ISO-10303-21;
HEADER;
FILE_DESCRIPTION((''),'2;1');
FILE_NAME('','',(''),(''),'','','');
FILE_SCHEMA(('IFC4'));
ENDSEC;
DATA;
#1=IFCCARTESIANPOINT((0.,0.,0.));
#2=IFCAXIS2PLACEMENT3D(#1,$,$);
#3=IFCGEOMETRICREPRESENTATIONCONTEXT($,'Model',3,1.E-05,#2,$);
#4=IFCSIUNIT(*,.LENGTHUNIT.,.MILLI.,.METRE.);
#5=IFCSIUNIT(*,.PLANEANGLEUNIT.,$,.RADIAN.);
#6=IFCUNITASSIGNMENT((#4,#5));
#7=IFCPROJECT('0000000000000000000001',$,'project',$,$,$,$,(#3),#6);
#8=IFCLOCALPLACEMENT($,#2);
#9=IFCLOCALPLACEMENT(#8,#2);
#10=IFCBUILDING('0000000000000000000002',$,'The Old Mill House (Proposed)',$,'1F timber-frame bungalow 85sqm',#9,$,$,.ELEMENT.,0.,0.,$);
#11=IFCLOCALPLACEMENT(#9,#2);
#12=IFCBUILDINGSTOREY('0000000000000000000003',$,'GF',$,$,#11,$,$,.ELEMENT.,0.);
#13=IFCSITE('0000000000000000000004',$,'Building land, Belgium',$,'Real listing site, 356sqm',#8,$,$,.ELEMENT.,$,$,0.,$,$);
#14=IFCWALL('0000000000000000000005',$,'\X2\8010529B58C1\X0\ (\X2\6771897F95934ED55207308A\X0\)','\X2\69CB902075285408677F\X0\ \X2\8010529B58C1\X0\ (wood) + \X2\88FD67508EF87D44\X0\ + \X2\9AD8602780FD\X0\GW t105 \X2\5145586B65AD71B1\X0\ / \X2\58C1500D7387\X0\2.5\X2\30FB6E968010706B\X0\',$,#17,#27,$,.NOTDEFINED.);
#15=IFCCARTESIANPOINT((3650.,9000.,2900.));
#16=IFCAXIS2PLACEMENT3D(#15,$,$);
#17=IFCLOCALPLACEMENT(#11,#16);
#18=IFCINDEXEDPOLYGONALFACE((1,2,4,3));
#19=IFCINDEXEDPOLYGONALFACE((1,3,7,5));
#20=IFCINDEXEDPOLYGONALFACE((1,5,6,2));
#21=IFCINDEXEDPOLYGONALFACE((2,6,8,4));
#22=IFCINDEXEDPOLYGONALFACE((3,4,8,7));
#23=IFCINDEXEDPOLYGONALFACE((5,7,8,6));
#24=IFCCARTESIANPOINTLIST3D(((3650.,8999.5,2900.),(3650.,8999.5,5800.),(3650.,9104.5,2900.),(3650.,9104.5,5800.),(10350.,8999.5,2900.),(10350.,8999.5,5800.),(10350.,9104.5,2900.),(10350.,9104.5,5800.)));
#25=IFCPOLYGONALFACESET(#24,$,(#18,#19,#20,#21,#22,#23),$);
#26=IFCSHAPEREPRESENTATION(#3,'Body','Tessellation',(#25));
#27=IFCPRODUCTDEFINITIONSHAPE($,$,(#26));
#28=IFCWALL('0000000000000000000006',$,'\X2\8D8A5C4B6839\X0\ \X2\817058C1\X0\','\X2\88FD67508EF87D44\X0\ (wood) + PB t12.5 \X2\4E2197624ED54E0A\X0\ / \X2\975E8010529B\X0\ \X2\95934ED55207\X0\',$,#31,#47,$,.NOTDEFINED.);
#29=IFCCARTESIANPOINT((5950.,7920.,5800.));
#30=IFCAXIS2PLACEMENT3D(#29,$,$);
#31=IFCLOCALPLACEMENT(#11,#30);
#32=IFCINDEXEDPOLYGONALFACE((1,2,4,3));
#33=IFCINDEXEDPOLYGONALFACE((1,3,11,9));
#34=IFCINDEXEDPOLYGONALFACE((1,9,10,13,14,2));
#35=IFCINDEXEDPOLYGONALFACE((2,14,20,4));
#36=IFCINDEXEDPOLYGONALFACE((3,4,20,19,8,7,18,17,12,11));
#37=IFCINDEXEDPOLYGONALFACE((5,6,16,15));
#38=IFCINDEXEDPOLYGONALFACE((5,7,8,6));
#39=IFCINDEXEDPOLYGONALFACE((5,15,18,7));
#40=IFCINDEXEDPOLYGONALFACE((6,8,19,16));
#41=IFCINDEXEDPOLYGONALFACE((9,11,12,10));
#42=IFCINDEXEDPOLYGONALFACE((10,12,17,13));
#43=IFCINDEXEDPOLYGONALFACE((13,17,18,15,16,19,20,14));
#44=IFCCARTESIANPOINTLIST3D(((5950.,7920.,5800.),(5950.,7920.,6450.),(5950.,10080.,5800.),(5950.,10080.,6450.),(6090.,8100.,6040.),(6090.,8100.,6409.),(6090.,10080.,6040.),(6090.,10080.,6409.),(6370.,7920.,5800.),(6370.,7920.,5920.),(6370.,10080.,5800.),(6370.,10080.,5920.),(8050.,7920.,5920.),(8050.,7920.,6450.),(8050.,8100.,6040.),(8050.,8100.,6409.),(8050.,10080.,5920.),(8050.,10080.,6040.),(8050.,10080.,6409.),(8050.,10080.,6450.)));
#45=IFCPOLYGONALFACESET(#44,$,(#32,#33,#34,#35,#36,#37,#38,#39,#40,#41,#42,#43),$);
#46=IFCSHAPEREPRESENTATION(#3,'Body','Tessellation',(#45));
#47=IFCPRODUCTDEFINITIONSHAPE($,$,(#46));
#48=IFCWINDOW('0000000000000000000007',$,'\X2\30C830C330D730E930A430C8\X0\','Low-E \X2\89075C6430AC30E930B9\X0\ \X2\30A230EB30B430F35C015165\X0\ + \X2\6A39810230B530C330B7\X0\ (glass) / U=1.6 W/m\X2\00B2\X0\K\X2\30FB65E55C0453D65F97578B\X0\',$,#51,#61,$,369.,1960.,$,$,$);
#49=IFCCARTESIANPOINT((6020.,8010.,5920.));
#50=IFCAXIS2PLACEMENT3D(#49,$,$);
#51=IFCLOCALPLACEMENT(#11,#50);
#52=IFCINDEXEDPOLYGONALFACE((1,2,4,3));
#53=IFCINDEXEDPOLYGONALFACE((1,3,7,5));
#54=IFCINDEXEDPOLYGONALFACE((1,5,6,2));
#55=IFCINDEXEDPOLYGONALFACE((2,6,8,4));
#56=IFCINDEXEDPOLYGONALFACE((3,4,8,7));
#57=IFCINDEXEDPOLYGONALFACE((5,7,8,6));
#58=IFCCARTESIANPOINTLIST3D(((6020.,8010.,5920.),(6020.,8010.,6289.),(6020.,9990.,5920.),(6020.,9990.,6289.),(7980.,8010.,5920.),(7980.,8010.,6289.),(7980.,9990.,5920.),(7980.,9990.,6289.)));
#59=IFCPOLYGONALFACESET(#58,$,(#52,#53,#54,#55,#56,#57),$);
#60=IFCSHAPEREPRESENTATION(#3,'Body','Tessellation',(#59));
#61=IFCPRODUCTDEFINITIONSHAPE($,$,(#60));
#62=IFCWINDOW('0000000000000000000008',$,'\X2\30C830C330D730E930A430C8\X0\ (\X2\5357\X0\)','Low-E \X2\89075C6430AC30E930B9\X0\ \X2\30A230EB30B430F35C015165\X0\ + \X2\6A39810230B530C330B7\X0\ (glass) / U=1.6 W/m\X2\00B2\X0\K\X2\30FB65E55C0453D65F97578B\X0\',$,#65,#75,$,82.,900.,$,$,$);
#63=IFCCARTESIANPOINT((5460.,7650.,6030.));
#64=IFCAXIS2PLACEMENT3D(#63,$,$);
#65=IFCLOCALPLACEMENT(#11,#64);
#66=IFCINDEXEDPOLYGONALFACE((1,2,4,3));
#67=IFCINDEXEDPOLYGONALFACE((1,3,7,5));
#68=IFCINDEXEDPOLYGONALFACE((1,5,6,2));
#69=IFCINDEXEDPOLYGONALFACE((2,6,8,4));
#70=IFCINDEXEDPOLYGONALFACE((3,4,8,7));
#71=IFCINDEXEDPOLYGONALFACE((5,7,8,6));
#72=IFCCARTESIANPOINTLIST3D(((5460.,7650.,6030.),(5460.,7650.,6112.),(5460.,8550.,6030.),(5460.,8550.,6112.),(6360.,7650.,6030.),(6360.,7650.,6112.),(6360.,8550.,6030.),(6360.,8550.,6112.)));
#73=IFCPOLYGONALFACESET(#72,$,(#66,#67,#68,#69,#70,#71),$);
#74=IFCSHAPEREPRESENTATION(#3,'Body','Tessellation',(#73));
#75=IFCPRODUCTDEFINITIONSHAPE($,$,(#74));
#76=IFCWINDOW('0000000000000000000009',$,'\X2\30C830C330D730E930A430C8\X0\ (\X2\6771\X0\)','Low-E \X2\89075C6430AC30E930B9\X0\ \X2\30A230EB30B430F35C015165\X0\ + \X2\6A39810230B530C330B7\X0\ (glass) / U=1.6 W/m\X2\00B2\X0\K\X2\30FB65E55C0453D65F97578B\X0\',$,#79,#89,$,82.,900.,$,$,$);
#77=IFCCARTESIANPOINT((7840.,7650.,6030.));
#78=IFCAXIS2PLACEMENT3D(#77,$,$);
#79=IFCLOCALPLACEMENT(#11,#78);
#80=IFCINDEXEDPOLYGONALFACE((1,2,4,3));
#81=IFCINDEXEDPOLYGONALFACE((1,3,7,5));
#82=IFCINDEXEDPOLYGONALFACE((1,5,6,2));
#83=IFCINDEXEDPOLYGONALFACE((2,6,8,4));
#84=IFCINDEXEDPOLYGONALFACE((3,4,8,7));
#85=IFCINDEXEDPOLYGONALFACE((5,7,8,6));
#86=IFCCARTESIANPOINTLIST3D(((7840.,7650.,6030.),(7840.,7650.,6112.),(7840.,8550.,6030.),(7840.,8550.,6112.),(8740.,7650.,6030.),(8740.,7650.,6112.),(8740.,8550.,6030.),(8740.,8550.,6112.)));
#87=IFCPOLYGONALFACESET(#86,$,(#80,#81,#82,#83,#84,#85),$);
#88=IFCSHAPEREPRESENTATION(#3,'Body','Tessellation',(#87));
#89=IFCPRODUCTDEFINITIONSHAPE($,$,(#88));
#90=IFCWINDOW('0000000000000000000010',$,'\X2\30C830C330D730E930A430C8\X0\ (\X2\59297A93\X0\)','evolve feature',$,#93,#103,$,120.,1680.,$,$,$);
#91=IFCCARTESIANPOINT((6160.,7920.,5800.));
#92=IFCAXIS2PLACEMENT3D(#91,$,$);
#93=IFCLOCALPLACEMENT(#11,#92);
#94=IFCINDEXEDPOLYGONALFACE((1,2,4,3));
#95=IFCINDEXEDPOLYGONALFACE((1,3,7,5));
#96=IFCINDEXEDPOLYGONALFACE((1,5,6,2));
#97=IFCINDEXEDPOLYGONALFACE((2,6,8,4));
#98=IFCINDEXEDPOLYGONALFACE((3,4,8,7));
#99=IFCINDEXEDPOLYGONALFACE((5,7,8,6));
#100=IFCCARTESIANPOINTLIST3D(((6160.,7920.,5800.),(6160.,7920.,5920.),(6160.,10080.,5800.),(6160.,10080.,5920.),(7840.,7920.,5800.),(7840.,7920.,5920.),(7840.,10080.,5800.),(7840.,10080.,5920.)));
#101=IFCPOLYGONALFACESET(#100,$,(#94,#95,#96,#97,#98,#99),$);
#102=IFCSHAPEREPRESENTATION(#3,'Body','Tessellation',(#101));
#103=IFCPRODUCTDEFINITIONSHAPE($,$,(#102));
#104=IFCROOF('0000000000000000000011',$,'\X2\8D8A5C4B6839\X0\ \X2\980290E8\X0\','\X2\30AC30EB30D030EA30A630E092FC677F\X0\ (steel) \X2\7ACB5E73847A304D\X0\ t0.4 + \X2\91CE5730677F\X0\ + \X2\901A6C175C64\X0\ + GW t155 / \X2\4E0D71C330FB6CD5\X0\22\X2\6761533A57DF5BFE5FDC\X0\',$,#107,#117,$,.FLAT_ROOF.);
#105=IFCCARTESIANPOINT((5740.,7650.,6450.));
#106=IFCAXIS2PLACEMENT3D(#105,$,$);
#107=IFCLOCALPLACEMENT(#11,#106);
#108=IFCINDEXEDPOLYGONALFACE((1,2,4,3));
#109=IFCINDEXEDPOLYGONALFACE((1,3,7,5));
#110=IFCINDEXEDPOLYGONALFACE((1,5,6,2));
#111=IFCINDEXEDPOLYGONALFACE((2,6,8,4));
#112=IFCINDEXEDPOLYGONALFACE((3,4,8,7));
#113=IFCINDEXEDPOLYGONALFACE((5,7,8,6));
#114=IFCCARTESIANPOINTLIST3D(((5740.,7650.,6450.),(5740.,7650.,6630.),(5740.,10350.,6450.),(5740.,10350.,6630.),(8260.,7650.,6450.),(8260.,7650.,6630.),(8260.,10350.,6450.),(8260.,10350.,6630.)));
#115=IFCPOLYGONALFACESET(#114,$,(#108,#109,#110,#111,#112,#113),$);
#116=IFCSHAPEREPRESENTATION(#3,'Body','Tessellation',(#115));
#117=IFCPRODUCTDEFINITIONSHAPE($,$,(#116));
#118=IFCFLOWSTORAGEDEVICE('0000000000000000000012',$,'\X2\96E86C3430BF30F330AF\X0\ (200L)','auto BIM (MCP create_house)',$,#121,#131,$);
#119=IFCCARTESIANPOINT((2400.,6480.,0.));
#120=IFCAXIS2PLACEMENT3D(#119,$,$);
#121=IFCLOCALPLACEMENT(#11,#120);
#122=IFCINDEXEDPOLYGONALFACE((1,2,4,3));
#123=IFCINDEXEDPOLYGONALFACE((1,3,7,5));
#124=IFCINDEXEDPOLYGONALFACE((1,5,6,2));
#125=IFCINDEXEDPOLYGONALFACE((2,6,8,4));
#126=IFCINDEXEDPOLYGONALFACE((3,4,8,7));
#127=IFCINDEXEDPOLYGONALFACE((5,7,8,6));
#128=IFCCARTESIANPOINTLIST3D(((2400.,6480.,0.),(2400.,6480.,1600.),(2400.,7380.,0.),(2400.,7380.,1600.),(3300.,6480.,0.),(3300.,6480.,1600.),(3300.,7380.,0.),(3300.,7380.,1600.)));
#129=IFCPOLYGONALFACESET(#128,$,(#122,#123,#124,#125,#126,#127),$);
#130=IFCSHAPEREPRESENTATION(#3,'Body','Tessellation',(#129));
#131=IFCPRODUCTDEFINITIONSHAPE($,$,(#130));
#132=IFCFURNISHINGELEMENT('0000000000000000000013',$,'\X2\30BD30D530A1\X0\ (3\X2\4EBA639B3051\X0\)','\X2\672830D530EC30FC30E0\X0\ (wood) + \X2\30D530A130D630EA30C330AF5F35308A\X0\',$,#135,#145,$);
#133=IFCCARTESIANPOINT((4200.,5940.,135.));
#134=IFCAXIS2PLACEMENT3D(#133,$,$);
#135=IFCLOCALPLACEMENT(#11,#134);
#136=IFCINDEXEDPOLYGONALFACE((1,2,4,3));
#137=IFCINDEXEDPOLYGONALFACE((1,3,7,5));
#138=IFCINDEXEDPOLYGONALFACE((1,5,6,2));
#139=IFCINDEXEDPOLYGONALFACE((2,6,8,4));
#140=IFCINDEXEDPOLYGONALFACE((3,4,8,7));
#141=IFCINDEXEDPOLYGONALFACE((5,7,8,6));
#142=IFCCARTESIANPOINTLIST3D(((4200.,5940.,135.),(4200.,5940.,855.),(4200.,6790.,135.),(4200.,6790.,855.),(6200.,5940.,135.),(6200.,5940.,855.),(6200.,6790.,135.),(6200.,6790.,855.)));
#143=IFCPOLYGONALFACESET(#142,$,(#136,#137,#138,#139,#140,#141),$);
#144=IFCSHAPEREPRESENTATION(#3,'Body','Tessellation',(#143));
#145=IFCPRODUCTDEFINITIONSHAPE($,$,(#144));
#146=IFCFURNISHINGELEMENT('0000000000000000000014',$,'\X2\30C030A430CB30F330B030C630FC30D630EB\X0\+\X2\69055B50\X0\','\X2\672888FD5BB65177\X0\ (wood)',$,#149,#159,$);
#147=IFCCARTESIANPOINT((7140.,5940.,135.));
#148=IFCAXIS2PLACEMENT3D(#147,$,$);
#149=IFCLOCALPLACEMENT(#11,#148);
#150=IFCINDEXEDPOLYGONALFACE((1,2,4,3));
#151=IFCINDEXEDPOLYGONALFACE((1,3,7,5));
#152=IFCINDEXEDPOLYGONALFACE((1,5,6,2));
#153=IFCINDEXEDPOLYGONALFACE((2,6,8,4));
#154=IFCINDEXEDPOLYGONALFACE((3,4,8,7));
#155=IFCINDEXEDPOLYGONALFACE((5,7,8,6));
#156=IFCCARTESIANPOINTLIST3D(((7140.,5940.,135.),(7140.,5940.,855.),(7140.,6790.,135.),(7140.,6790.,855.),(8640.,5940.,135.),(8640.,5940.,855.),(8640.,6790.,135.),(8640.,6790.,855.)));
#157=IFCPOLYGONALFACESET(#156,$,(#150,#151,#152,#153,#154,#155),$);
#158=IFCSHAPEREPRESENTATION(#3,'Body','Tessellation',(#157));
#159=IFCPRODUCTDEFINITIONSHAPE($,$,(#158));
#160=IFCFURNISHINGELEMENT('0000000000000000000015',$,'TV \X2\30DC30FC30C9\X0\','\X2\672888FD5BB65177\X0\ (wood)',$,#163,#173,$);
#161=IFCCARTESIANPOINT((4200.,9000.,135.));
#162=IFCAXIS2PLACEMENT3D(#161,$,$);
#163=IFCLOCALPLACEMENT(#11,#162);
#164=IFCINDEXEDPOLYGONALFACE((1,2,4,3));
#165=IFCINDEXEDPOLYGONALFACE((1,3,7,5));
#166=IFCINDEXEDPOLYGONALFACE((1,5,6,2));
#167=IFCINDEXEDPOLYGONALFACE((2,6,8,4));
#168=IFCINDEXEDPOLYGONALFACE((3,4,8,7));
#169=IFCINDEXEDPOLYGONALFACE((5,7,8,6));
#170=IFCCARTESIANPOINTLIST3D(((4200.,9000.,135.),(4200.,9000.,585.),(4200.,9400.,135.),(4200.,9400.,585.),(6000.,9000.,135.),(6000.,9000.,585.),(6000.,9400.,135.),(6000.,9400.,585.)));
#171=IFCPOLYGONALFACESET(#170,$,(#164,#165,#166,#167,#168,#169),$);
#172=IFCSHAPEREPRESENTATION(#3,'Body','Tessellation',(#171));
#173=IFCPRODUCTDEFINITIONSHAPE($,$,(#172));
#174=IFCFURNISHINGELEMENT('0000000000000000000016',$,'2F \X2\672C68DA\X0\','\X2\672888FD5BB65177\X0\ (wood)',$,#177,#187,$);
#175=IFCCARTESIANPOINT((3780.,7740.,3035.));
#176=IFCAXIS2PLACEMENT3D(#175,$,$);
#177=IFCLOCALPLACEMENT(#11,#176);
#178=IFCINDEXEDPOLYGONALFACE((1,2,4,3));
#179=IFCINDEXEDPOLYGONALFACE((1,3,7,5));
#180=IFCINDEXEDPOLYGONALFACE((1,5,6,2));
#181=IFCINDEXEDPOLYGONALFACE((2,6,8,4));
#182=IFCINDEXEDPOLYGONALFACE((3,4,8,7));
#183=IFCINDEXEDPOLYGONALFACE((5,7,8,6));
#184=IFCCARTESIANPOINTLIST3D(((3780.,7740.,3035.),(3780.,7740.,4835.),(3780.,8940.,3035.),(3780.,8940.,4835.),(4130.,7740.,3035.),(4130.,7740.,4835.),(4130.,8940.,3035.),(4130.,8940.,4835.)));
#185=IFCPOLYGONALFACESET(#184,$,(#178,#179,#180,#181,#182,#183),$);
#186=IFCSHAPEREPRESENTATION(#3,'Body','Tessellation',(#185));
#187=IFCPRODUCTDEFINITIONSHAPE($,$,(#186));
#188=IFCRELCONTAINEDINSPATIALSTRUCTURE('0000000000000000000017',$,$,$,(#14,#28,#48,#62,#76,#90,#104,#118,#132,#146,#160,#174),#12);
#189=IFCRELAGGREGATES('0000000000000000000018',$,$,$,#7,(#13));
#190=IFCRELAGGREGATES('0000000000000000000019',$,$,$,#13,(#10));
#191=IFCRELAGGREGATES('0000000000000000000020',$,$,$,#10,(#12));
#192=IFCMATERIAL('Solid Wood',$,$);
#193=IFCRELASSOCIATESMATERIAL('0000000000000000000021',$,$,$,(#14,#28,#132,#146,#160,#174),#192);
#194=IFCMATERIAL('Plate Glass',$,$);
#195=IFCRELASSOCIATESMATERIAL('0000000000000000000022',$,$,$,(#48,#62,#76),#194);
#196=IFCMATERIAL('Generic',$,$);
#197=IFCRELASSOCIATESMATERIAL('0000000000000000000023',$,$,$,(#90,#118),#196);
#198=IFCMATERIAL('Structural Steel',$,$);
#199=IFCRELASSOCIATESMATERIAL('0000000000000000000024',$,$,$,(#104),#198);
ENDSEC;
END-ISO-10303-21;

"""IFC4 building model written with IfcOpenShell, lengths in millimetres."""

from ifc_helpers import new_model, si_unit, frame, frame_2d, origin, place, context, project, spatial, rectangle, extrude, material, element, fill, save


model = new_model("IFC4")

# Units and contexts
model_context = context("Model", 3, precision=1e-05, world=origin())
ifc_project = project(units=[si_unit("LENGTHUNIT", "METRE", prefix="MILLI"), si_unit("PLANEANGLEUNIT", "RADIAN")], contexts=[model_context])

# Site, building, storey
site_placement = place(None, origin())
site = spatial("IfcSite", under=ifc_project, at=site_placement, Name="Building land, Belgium", ObjectType="Real listing site, 356sqm", CompositionType="ELEMENT", RefElevation=0.0)
building_placement = place(site_placement, origin())
building = spatial("IfcBuilding", under=site, at=building_placement, Name="The Old Mill House (Proposed)", ObjectType="1F timber-frame bungalow 85sqm", CompositionType="ELEMENT", ElevationOfRefHeight=0.0, ElevationOfTerrain=0.0)
storey_placement = place(building_placement, origin())
storey = spatial("IfcBuildingStorey", under=building, at=storey_placement, Name="GF", CompositionType="ELEMENT", Elevation=0.0)

# Wall
ifc_material_1 = material(Name="Solid Wood")
wall_1_placement = place(storey_placement, frame((3650.0, 9000.0, 2900.0)))
element("IfcWall", 1, at=wall_1_placement, inside=storey, material=ifc_material_1, Name="耐力壁 (東西間仕切り)", Description="構造用合板 耐力壁 (wood) + 製材軸組 + 高性能GW t105 充填断熱 / 壁倍率2.5・準耐火", PredefinedType="NOTDEFINED", context=model_context, shape_type="SweptSolid", body=[
    extrude(rectangle(XDim=6700.0, YDim=105.0, at=frame_2d((3350.0, 52.0))), frame((3650.0, 9000.0, 2900.0)), (0.0, 0.0, 1.0), 2900.0),
])

# Wall, openings, windows
wall_2_placement = place(storey_placement, frame((5950.0, 7920.0, 5800.0)))
wall_2 = element("IfcWall", 2, at=wall_2_placement, inside=storey, material=ifc_material_1, Name="越屋根 腰壁", Description="製材軸組 (wood) + PB t12.5 両面仕上 / 非耐力 間仕切", PredefinedType="NOTDEFINED", context=model_context, shape_type="SweptSolid", body=[
    extrude(rectangle(XDim=2100.0, YDim=2160.0, at=frame_2d((1050.0, 1080.0))), frame((5950.0, 7920.0, 5800.0)), (0.0, 0.0, 1.0), 650.0),
])
opening_1_placement = place(storey_placement, frame((6020.0, 8010.0, 5920.0)))
opening_1 = element("IfcOpeningElement", 3, at=opening_1_placement, cuts=wall_2, PredefinedType="NOTDEFINED", context=model_context, shape_type="SweptSolid", body=[
    extrude(rectangle(XDim=1960.0, YDim=1980.0, at=frame_2d((980.0, 990.0))), frame((6020.0, 8010.0, 5920.0)), (0.0, 0.0, 1.0), 369.0),
])
opening_2_placement = place(storey_placement, frame((5460.0, 7650.0, 6030.0)))
opening_2 = element("IfcOpeningElement", 4, at=opening_2_placement, cuts=wall_2, PredefinedType="NOTDEFINED", context=model_context, shape_type="SweptSolid", body=[
    extrude(rectangle(XDim=900.0, YDim=900.0, at=frame_2d((450.0, 450.0))), frame((5460.0, 7650.0, 6030.0)), (0.0, 0.0, 1.0), 82.0),
])
opening_3_placement = place(storey_placement, frame((7840.0, 7650.0, 6030.0)))
opening_3 = element("IfcOpeningElement", 5, at=opening_3_placement, cuts=wall_2, PredefinedType="NOTDEFINED", context=model_context, shape_type="SweptSolid", body=[
    extrude(rectangle(XDim=900.0, YDim=900.0, at=frame_2d((450.0, 450.0))), frame((7840.0, 7650.0, 6030.0)), (0.0, 0.0, 1.0), 82.0),
])
opening_4_placement = place(storey_placement, frame((6160.0, 7920.0, 5800.0)))
opening_4 = element("IfcOpeningElement", 6, at=opening_4_placement, cuts=wall_2, PredefinedType="NOTDEFINED", context=model_context, shape_type="SweptSolid", body=[
    extrude(rectangle(XDim=1680.0, YDim=2160.0, at=frame_2d((840.0, 1080.0))), frame((6160.0, 7920.0, 5800.0)), (0.0, 0.0, 1.0), 120.0),
])
ifc_material_2 = material(Name="Plate Glass")
window_1_placement = place(storey_placement, frame((6020.0, 8010.0, 5920.0)))
window_1 = element("IfcWindow", 7, at=window_1_placement, inside=storey, material=ifc_material_2, Name="トップライト", Description="Low-E 複層ガラス アルゴン封入 + 樹脂サッシ (glass) / U=1.6 W/m²K・日射取得型", OverallHeight=369.0, OverallWidth=1960.0, context=model_context, shape_type="SweptSolid", body=[
    extrude(rectangle(XDim=1960.0, YDim=1980.0, at=frame_2d((980.0, 990.0))), frame((6020.0, 8010.0, 5920.0)), (0.0, 0.0, 1.0), 369.0),
])
fill(opening_1, window_1)
window_2_placement = place(storey_placement, frame((5460.0, 7650.0, 6030.0)))
window_2 = element("IfcWindow", 8, at=window_2_placement, inside=storey, material=ifc_material_2, Name="トップライト (南)", Description="Low-E 複層ガラス アルゴン封入 + 樹脂サッシ (glass) / U=1.6 W/m²K・日射取得型", OverallHeight=82.0, OverallWidth=900.0, context=model_context, shape_type="SweptSolid", body=[
    extrude(rectangle(XDim=900.0, YDim=900.0, at=frame_2d((450.0, 450.0))), frame((5460.0, 7650.0, 6030.0)), (0.0, 0.0, 1.0), 82.0),
])
fill(opening_2, window_2)
window_3_placement = place(storey_placement, frame((7840.0, 7650.0, 6030.0)))
window_3 = element("IfcWindow", 9, at=window_3_placement, inside=storey, material=ifc_material_2, Name="トップライト (東)", Description="Low-E 複層ガラス アルゴン封入 + 樹脂サッシ (glass) / U=1.6 W/m²K・日射取得型", OverallHeight=82.0, OverallWidth=900.0, context=model_context, shape_type="SweptSolid", body=[
    extrude(rectangle(XDim=900.0, YDim=900.0, at=frame_2d((450.0, 450.0))), frame((7840.0, 7650.0, 6030.0)), (0.0, 0.0, 1.0), 82.0),
])
fill(opening_3, window_3)
ifc_material_3 = material(Name="Generic")
window_4_placement = place(storey_placement, frame((6160.0, 7920.0, 5800.0)))
window_4 = element("IfcWindow", 10, at=window_4_placement, inside=storey, material=ifc_material_3, Name="トップライト (天窓)", Description="evolve feature", OverallHeight=120.0, OverallWidth=1680.0, context=model_context, shape_type="SweptSolid", body=[
    extrude(rectangle(XDim=1680.0, YDim=2160.0, at=frame_2d((840.0, 1080.0))), frame((6160.0, 7920.0, 5800.0)), (0.0, 0.0, 1.0), 120.0),
])
fill(opening_4, window_4)

# Roof
ifc_material_4 = material(Name="Structural Steel")
roof_placement = place(storey_placement, frame((5740.0, 7650.0, 6450.0)))
element("IfcRoof", 11, at=roof_placement, inside=storey, material=ifc_material_4, Name="越屋根 頂部", Description="ガルバリウム鋼板 (steel) 立平葺き t0.4 + 野地板 + 通気層 + GW t155 / 不燃・法22条区域対応", PredefinedType="FLAT_ROOF", context=model_context, shape_type="SweptSolid", body=[
    extrude(rectangle(XDim=2520.0, YDim=2700.0, at=frame_2d((1260.0, 1350.0))), frame((5740.0, 7650.0, 6450.0)), (0.0, 0.0, 1.0), 180.0),
])

# Flow storage device
flow_storage_device_placement = place(storey_placement, frame((2400.0, 6480.0, 0.0)))
element("IfcFlowStorageDevice", 12, at=flow_storage_device_placement, inside=storey, material=ifc_material_3, Name="雨水タンク (200L)", Description="auto BIM (MCP create_house)", context=model_context, shape_type="SweptSolid", body=[
    extrude(rectangle(XDim=900.0, YDim=900.0, at=frame_2d((450.0, 450.0))), frame((2400.0, 6480.0, 0.0)), (0.0, 0.0, 1.0), 1600.0),
])

# Furnishing elements
furnishing_1_placement = place(storey_placement, frame((4200.0, 5940.0, 135.0)))
element("IfcFurnishingElement", 13, at=furnishing_1_placement, inside=storey, material=ifc_material_1, Name="ソファ (3人掛け)", Description="木フレーム (wood) + ファブリック張り", context=model_context, shape_type="SweptSolid", body=[
    extrude(rectangle(XDim=2000.0, YDim=850.0, at=frame_2d((1000.0, 425.0))), frame((4200.0, 5940.0, 135.0)), (0.0, 0.0, 1.0), 720.0),
])
furnishing_2_placement = place(storey_placement, frame((7140.0, 5940.0, 135.0)))
element("IfcFurnishingElement", 14, at=furnishing_2_placement, inside=storey, material=ifc_material_1, Name="ダイニングテーブル+椅子", Description="木製家具 (wood)", context=model_context, shape_type="SweptSolid", body=[
    extrude(rectangle(XDim=1500.0, YDim=850.0, at=frame_2d((750.0, 425.0))), frame((7140.0, 5940.0, 135.0)), (0.0, 0.0, 1.0), 720.0),
])
furnishing_3_placement = place(storey_placement, frame((4200.0, 9000.0, 135.0)))
element("IfcFurnishingElement", 15, at=furnishing_3_placement, inside=storey, material=ifc_material_1, Name="TV ボード", Description="木製家具 (wood)", context=model_context, shape_type="SweptSolid", body=[
    extrude(rectangle(XDim=1800.0, YDim=400.0, at=frame_2d((900.0, 200.0))), frame((4200.0, 9000.0, 135.0)), (0.0, 0.0, 1.0), 450.0),
])
furnishing_4_placement = place(storey_placement, frame((3780.0, 7740.0, 3035.0)))
element("IfcFurnishingElement", 16, at=furnishing_4_placement, inside=storey, material=ifc_material_1, Name="2F 本棚", Description="木製家具 (wood)", context=model_context, shape_type="SweptSolid", body=[
    extrude(rectangle(XDim=350.0, YDim=1200.0, at=frame_2d((175.0, 600.0))), frame((3780.0, 7740.0, 3035.0)), (0.0, 0.0, 1.0), 1800.0),
])

save(model, "model.ifc")
